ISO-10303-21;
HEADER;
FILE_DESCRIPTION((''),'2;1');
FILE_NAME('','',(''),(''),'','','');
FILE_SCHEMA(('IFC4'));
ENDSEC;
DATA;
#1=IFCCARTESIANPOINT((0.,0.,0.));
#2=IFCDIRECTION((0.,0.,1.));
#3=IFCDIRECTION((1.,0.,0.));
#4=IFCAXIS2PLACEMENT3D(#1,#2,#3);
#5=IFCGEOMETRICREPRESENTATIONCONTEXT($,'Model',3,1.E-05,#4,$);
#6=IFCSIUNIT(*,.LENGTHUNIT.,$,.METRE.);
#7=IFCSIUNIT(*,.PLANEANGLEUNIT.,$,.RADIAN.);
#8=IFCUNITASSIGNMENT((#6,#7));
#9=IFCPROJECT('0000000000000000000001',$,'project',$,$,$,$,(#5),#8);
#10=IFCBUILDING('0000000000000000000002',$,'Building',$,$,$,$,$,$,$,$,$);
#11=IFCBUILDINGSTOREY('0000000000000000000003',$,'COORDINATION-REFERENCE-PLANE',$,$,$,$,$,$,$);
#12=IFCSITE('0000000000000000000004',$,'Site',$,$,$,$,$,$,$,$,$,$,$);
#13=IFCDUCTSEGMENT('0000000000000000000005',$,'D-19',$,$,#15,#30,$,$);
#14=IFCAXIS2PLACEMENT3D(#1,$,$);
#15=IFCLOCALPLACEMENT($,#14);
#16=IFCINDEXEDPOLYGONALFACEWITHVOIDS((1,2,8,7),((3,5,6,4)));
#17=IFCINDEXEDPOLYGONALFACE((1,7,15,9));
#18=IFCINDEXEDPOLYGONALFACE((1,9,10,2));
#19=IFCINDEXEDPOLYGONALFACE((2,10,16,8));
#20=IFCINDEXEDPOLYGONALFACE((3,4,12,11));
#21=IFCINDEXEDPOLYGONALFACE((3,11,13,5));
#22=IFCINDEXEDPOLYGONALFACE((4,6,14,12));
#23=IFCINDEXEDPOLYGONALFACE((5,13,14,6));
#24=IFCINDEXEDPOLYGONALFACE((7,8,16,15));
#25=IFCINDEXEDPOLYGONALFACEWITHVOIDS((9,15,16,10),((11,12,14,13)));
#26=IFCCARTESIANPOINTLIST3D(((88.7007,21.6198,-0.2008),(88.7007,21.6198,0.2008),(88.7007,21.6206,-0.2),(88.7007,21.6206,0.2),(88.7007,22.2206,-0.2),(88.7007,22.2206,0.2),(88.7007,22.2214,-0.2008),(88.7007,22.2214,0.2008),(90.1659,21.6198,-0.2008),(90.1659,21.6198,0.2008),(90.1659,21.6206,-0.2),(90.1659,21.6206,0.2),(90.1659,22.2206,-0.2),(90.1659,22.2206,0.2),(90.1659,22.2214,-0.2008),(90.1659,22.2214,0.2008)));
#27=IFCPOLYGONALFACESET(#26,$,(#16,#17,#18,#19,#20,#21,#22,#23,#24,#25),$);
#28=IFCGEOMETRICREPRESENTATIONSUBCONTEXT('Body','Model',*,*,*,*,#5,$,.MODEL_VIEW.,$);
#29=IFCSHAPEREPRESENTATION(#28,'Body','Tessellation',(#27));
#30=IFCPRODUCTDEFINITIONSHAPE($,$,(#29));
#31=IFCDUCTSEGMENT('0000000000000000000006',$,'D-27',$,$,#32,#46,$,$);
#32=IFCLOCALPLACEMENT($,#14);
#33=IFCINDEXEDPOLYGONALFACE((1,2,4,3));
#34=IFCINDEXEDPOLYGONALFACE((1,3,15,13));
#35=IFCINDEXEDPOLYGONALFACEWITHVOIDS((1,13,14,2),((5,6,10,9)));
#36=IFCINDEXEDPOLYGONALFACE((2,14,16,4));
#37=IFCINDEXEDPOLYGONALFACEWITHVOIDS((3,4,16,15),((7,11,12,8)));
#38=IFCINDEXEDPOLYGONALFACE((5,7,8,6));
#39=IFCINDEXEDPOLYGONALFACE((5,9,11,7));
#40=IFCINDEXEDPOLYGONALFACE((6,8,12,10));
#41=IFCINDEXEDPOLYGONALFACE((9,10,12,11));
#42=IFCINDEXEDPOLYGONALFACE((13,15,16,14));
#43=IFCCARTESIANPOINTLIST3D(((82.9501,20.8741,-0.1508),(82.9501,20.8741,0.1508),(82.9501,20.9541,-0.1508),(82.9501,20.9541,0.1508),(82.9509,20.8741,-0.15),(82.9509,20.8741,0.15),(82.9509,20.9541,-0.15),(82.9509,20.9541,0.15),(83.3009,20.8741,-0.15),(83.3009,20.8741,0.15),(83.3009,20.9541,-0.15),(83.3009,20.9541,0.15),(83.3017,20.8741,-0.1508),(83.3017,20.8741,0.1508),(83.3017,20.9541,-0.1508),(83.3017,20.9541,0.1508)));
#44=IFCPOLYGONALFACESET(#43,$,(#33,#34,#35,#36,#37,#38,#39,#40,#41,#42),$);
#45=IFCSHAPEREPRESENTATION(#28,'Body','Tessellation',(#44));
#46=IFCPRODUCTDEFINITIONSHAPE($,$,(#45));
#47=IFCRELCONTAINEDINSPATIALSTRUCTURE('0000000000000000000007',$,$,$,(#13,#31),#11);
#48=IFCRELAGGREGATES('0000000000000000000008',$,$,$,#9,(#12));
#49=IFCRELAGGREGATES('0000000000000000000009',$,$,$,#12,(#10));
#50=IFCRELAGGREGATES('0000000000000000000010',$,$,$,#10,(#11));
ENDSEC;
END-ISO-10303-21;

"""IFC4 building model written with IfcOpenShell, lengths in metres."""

from ifc_helpers import new_model, si_unit, frame, origin, origin_with_axes, place, context, subcontext, project, spatial, hollow_rectangle, extrude, element, save


model = new_model("IFC4")

# Units and contexts
model_context = context("Model", 3, precision=1e-05, world=origin_with_axes())
body_context_1 = subcontext(model_context, "Body", "Model", "MODEL_VIEW")
ifc_project = project(units=[si_unit("LENGTHUNIT", "METRE"), si_unit("PLANEANGLEUNIT", "RADIAN")], contexts=[model_context])

# Site, building, storey
site = spatial("IfcSite", under=ifc_project, Name="Site")
building = spatial("IfcBuilding", under=site, Name="Building")
storey = spatial("IfcBuildingStorey", under=building, Name="COORDINATION-REFERENCE-PLANE")

# Duct segments
duct_segment_1_placement = place(None, frame((88.7007, 21.9206, 0.0), z_axis=(1.0, 0.0, 0.0), x_axis=(0.0, 1.0, 0.0)))
element("IfcDuctSegment", 1, at=duct_segment_1_placement, inside=storey, Name="D-19", context=body_context_1, shape_type="SweptSolid", body=[
    extrude(hollow_rectangle(XDim=0.6016, YDim=0.4016, WallThickness=0.0008), origin(), (0.0, 0.0, 1.0), 1.4652),
])
duct_segment_2_placement = place(None, frame((83.1259, 20.8741, 0.0), z_axis=(0.0, 1.0, 0.0), x_axis=(1.0, 0.0, 0.0)))
element("IfcDuctSegment", 2, at=duct_segment_2_placement, inside=storey, Name="D-27", context=body_context_1, shape_type="SweptSolid", body=[
    extrude(hollow_rectangle(XDim=0.3516, YDim=0.3016, WallThickness=0.0008), origin(), (0.0, 0.0, 1.0), 0.08),
])

save(model, "model.ifc")
